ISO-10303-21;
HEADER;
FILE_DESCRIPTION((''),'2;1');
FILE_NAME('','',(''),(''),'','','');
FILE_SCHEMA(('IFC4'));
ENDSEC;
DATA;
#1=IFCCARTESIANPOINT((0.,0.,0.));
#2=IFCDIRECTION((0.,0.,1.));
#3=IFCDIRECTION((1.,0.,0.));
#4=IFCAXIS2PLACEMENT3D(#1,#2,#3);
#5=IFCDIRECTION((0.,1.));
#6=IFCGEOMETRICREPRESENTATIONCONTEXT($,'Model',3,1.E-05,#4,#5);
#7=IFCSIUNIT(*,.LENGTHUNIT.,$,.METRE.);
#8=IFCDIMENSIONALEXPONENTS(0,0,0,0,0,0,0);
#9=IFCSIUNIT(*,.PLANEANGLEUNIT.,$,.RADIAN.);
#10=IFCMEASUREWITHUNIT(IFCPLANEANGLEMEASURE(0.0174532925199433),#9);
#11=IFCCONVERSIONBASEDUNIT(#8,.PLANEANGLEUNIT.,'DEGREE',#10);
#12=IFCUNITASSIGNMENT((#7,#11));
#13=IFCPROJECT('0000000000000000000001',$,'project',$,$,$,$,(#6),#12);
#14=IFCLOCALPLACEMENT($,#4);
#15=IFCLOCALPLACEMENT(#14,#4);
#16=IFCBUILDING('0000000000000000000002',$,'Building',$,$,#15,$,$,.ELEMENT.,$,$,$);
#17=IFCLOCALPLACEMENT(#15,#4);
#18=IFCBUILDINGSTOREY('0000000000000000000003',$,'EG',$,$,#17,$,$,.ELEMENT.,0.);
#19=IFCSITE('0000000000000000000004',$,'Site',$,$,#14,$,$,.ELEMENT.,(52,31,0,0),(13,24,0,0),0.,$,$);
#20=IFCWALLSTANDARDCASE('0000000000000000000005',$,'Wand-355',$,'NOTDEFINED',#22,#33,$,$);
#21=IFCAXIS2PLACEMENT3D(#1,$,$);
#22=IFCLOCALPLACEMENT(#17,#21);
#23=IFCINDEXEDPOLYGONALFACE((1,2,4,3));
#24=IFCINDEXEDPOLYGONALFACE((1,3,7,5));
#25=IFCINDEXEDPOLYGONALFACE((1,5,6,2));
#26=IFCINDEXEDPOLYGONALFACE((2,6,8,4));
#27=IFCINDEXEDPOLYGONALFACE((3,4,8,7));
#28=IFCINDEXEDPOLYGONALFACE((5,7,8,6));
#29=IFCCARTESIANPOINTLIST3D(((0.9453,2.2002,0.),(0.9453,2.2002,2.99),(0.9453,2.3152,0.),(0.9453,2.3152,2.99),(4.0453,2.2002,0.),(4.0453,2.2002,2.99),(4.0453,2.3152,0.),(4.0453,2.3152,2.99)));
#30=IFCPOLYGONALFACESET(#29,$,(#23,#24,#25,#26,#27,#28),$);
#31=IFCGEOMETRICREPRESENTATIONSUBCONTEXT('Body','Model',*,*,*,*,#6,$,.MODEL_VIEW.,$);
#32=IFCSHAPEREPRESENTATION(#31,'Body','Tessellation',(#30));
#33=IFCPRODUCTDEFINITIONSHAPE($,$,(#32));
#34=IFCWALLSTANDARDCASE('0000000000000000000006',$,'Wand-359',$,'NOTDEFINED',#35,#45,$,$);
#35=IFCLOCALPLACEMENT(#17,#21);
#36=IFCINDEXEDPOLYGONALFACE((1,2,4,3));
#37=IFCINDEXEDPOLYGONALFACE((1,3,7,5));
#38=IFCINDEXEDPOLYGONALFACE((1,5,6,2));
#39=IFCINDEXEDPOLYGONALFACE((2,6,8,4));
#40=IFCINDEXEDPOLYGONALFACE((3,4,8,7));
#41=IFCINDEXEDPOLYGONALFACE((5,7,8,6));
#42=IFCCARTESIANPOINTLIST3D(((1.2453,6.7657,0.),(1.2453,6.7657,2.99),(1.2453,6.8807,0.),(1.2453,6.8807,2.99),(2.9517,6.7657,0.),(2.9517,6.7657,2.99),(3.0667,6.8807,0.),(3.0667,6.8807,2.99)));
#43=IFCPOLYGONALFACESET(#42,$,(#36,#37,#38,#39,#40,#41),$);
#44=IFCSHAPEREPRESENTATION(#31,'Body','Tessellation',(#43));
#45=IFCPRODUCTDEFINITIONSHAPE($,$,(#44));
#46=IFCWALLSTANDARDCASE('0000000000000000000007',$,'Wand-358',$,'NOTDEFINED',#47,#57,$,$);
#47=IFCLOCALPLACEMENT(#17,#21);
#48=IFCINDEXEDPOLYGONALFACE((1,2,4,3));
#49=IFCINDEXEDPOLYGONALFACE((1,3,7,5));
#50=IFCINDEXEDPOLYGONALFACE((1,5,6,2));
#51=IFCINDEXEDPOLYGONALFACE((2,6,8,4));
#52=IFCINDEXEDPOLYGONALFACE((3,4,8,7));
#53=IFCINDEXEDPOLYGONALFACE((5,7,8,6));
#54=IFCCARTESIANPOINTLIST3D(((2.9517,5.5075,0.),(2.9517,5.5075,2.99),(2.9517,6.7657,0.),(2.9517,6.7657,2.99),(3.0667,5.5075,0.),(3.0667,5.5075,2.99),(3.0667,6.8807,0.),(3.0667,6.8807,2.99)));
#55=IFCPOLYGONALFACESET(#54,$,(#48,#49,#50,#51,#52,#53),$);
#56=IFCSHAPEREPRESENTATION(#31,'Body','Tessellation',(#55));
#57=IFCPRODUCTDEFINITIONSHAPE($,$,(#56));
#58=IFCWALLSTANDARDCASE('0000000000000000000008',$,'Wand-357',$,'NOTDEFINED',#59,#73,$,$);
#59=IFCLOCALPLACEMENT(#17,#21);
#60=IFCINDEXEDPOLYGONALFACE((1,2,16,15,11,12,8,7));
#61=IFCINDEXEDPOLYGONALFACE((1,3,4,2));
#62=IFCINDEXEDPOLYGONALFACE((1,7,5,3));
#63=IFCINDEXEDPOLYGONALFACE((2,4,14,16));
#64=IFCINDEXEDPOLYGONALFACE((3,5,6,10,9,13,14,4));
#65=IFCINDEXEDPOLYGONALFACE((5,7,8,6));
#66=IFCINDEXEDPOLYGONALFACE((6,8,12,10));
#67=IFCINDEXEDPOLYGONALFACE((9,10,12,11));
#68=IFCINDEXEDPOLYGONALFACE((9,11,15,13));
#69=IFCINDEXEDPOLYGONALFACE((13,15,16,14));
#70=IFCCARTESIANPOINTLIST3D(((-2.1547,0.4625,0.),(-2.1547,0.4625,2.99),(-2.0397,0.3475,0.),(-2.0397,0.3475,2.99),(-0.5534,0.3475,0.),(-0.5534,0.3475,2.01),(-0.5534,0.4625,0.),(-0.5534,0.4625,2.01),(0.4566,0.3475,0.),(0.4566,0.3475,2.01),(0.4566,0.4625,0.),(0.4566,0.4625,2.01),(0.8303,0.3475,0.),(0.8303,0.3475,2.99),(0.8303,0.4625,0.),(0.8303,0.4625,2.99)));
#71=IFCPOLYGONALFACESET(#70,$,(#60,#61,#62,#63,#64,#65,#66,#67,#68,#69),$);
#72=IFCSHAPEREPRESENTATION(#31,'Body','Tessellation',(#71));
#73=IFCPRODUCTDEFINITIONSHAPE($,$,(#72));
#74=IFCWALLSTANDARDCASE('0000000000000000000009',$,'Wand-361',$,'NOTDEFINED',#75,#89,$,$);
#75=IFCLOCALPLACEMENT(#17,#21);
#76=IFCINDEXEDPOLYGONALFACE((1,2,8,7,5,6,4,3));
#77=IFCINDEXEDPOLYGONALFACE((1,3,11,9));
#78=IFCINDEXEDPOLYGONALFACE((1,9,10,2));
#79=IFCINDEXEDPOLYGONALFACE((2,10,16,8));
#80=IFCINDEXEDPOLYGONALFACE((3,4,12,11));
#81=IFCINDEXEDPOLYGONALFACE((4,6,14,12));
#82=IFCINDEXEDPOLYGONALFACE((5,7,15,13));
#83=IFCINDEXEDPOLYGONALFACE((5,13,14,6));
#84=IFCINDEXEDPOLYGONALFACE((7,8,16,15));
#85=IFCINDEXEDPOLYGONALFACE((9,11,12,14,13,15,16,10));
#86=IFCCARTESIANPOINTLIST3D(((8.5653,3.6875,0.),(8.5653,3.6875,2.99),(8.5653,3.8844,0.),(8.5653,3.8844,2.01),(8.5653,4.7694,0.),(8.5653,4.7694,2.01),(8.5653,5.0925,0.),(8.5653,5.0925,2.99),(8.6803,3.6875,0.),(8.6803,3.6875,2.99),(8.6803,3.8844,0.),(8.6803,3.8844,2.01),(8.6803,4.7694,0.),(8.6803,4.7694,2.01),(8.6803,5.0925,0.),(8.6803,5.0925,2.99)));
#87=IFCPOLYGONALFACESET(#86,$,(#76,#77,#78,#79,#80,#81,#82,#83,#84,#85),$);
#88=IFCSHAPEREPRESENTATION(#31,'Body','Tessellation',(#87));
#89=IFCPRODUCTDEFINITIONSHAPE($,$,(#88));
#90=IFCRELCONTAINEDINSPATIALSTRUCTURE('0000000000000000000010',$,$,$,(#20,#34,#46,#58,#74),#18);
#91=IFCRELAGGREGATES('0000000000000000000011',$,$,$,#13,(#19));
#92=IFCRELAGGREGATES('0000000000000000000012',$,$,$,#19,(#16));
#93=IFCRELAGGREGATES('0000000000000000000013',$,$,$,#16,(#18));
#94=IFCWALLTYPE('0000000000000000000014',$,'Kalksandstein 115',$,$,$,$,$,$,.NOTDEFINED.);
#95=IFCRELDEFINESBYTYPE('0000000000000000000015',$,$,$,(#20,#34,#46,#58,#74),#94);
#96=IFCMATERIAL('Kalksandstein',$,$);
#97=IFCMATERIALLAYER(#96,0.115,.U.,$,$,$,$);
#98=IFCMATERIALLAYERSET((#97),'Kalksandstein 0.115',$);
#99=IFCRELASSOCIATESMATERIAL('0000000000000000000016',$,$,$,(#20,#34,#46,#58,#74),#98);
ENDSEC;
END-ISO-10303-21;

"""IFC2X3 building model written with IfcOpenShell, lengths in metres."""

from ifc_helpers import new_model, entity, si_unit, converted_unit, direction, frame, origin_with_axes, origin_2d_with_axis, place, context, subcontext, project, spatial, polyline, rectangle, outline, extrude, material, layer, layer_set, layer_usage, type_object, element, save


model = new_model("IFC2X3")

# Units and contexts
model_context = context("Model", 3, precision=1e-05, world=origin_with_axes(), true_north=direction((0.0, 1.0)))
body_context = subcontext(model_context, "Body", "Model", "MODEL_VIEW")
ifc_project = project(units=[si_unit("LENGTHUNIT", "METRE"), converted_unit("PLANEANGLEUNIT", "DEGREE", entity("IfcPlaneAngleMeasure", 0.0174532925199433), si_unit("PLANEANGLEUNIT", "RADIAN"), dimensions=[0, 0, 0, 0, 0, 0, 0])], contexts=[model_context])

# Site, building, storey
site_placement = place(None, origin_with_axes())
site = spatial("IfcSite", under=ifc_project, at=site_placement, Name="Site", CompositionType="ELEMENT", RefLatitude=(52, 31, 0, 0), RefLongitude=(13, 24, 0, 0), RefElevation=0.0)
building_placement = place(site_placement, origin_with_axes())
building = spatial("IfcBuilding", under=site, at=building_placement, Name="Building", CompositionType="ELEMENT")
storey_placement = place(building_placement, origin_with_axes())
storey = spatial("IfcBuildingStorey", under=building, at=storey_placement, Name="EG", CompositionType="ELEMENT", Elevation=0.0)

# Shared definitions
ifc_material = material(Name="Kalksandstein")

# Shared definitions
ifc_layer_1 = layer(ifc_material, 0.115, ventilated="UNKNOWN")
ifc_layer_set_1 = layer_set([ifc_layer_1], Name="Kalksandstein 0.115")
wall_type_1 = type_object("IfcWallType", Name="Kalksandstein 115", PredefinedType="NOTDEFINED")

# Walls
ifc_layer_usage_1 = layer_usage(ifc_layer_set_1, "AXIS2", "POSITIVE", -0.115)
wall_1_placement = place(storey_placement, frame((0.8303, 2.3152, 0.0), z_axis=(0.0, 0.0, 1.0), x_axis=(1.0, 0.0, 0.0)))
element("IfcWallStandardCase", 1, at=wall_1_placement, inside=storey, type_object=wall_type_1, material=ifc_layer_usage_1, Name="Wand-355", ObjectType="NOTDEFINED", context=body_context, shape_type="SweptSolid", body=[
    extrude(outline(polyline([(0.115, -0.115), (3.215, -0.115), (3.215, 0.0), (0.115, 0.0), (0.115, -0.115)])), origin_with_axes(), (0.0, 0.0, 1.0), 2.99),
])
ifc_layer_usage_2 = layer_usage(ifc_layer_set_1, "AXIS2", "NEGATIVE", 0.115)
wall_2_placement = place(storey_placement, frame((3.0667, 6.8807, 0.0), z_axis=(0.0, 0.0, 1.0), x_axis=(-1.0, 0.0, 0.0)))
element("IfcWallStandardCase", 2, at=wall_2_placement, inside=storey, type_object=wall_type_1, material=ifc_layer_usage_2, Name="Wand-359", ObjectType="NOTDEFINED", context=body_context, shape_type="SweptSolid", body=[
    extrude(outline(polyline([(0.0, 0.0), (1.8214, 0.0), (1.8214, 0.115), (0.115, 0.115), (0.0, 0.0)])), origin_with_axes(), (0.0, 0.0, 1.0), 2.99),
])
ifc_layer_usage_3 = layer_usage(ifc_layer_set_1, "AXIS2", "NEGATIVE", 0.115)
wall_3_placement = place(storey_placement, frame((3.0667, 5.5075, 0.0), z_axis=(0.0, 0.0, 1.0), x_axis=(0.0, 1.0, 0.0)))
element("IfcWallStandardCase", 3, at=wall_3_placement, inside=storey, type_object=wall_type_1, material=ifc_layer_usage_3, Name="Wand-358", ObjectType="NOTDEFINED", context=body_context, shape_type="SweptSolid", body=[
    extrude(outline(polyline([(0.0, 0.0), (1.3732, 0.0), (1.2582, 0.115), (0.0, 0.115), (0.0, 0.0)])), origin_with_axes(), (0.0, 0.0, 1.0), 2.99),
])

# Walls, openings
ifc_layer_usage_4 = layer_usage(ifc_layer_set_1, "AXIS2", "POSITIVE", -0.115)
wall_4_placement = place(storey_placement, frame((-2.1547, 0.4625, 0.0), z_axis=(0.0, 0.0, 1.0), x_axis=(1.0, 0.0, 0.0)))
wall_4 = element("IfcWallStandardCase", 4, at=wall_4_placement, inside=storey, type_object=wall_type_1, material=ifc_layer_usage_4, Name="Wand-357", ObjectType="NOTDEFINED", context=body_context, shape_type="SweptSolid", body=[
    extrude(outline(polyline([(0.115, -0.115), (2.985, -0.115), (2.985, 0.0), (0.0, 0.0), (0.115, -0.115)])), origin_with_axes(), (0.0, 0.0, 1.0), 2.99),
])
opening_1_placement = place(wall_4_placement, frame((2.1063, 0.0, 0.0), z_axis=(0.0, 0.0, 1.0), x_axis=(1.0, 0.0, 0.0)))
element("IfcOpeningElement", 5, at=opening_1_placement, cuts=wall_4, context=body_context, shape_type="SweptSolid", body=[
    extrude(rectangle(XDim=1.01, YDim=2.01, at=origin_2d_with_axis()), frame((0.0, -0.115, 1.005), z_axis=(0.0, 1.0, 0.0), x_axis=(1.0, 0.0, 0.0)), (0.0, 0.0, 1.0), 0.345),
])
ifc_layer_usage_5 = layer_usage(ifc_layer_set_1, "AXIS2", "NEGATIVE", 0.115)
wall_5_placement = place(storey_placement, frame((8.6803, 3.6875, 0.0), z_axis=(0.0, 0.0, 1.0), x_axis=(0.0, 1.0, 0.0)))
wall_5 = element("IfcWallStandardCase", 6, at=wall_5_placement, inside=storey, type_object=wall_type_1, material=ifc_layer_usage_5, Name="Wand-361", ObjectType="NOTDEFINED", context=body_context, shape_type="SweptSolid", body=[
    extrude(outline(polyline([(0.0, 0.0), (1.405, 0.0), (1.405, 0.115), (0.0, 0.115), (0.0, 0.0)])), origin_with_axes(), (0.0, 0.0, 1.0), 2.99),
])
opening_2_placement = place(wall_5_placement, frame((0.6394, 0.0, 0.0), z_axis=(0.0, 0.0, 1.0), x_axis=(1.0, 0.0, 0.0)))
element("IfcOpeningElement", 7, at=opening_2_placement, cuts=wall_5, context=body_context, shape_type="SweptSolid", body=[
    extrude(rectangle(XDim=0.885, YDim=2.01, at=origin_2d_with_axis()), frame((0.0, -0.115, 1.005), z_axis=(0.0, -1.0, 0.0), x_axis=(-1.0, 0.0, 0.0)), (0.0, 0.0, -1.0), 0.345),
])

save(model, "model.ifc")
